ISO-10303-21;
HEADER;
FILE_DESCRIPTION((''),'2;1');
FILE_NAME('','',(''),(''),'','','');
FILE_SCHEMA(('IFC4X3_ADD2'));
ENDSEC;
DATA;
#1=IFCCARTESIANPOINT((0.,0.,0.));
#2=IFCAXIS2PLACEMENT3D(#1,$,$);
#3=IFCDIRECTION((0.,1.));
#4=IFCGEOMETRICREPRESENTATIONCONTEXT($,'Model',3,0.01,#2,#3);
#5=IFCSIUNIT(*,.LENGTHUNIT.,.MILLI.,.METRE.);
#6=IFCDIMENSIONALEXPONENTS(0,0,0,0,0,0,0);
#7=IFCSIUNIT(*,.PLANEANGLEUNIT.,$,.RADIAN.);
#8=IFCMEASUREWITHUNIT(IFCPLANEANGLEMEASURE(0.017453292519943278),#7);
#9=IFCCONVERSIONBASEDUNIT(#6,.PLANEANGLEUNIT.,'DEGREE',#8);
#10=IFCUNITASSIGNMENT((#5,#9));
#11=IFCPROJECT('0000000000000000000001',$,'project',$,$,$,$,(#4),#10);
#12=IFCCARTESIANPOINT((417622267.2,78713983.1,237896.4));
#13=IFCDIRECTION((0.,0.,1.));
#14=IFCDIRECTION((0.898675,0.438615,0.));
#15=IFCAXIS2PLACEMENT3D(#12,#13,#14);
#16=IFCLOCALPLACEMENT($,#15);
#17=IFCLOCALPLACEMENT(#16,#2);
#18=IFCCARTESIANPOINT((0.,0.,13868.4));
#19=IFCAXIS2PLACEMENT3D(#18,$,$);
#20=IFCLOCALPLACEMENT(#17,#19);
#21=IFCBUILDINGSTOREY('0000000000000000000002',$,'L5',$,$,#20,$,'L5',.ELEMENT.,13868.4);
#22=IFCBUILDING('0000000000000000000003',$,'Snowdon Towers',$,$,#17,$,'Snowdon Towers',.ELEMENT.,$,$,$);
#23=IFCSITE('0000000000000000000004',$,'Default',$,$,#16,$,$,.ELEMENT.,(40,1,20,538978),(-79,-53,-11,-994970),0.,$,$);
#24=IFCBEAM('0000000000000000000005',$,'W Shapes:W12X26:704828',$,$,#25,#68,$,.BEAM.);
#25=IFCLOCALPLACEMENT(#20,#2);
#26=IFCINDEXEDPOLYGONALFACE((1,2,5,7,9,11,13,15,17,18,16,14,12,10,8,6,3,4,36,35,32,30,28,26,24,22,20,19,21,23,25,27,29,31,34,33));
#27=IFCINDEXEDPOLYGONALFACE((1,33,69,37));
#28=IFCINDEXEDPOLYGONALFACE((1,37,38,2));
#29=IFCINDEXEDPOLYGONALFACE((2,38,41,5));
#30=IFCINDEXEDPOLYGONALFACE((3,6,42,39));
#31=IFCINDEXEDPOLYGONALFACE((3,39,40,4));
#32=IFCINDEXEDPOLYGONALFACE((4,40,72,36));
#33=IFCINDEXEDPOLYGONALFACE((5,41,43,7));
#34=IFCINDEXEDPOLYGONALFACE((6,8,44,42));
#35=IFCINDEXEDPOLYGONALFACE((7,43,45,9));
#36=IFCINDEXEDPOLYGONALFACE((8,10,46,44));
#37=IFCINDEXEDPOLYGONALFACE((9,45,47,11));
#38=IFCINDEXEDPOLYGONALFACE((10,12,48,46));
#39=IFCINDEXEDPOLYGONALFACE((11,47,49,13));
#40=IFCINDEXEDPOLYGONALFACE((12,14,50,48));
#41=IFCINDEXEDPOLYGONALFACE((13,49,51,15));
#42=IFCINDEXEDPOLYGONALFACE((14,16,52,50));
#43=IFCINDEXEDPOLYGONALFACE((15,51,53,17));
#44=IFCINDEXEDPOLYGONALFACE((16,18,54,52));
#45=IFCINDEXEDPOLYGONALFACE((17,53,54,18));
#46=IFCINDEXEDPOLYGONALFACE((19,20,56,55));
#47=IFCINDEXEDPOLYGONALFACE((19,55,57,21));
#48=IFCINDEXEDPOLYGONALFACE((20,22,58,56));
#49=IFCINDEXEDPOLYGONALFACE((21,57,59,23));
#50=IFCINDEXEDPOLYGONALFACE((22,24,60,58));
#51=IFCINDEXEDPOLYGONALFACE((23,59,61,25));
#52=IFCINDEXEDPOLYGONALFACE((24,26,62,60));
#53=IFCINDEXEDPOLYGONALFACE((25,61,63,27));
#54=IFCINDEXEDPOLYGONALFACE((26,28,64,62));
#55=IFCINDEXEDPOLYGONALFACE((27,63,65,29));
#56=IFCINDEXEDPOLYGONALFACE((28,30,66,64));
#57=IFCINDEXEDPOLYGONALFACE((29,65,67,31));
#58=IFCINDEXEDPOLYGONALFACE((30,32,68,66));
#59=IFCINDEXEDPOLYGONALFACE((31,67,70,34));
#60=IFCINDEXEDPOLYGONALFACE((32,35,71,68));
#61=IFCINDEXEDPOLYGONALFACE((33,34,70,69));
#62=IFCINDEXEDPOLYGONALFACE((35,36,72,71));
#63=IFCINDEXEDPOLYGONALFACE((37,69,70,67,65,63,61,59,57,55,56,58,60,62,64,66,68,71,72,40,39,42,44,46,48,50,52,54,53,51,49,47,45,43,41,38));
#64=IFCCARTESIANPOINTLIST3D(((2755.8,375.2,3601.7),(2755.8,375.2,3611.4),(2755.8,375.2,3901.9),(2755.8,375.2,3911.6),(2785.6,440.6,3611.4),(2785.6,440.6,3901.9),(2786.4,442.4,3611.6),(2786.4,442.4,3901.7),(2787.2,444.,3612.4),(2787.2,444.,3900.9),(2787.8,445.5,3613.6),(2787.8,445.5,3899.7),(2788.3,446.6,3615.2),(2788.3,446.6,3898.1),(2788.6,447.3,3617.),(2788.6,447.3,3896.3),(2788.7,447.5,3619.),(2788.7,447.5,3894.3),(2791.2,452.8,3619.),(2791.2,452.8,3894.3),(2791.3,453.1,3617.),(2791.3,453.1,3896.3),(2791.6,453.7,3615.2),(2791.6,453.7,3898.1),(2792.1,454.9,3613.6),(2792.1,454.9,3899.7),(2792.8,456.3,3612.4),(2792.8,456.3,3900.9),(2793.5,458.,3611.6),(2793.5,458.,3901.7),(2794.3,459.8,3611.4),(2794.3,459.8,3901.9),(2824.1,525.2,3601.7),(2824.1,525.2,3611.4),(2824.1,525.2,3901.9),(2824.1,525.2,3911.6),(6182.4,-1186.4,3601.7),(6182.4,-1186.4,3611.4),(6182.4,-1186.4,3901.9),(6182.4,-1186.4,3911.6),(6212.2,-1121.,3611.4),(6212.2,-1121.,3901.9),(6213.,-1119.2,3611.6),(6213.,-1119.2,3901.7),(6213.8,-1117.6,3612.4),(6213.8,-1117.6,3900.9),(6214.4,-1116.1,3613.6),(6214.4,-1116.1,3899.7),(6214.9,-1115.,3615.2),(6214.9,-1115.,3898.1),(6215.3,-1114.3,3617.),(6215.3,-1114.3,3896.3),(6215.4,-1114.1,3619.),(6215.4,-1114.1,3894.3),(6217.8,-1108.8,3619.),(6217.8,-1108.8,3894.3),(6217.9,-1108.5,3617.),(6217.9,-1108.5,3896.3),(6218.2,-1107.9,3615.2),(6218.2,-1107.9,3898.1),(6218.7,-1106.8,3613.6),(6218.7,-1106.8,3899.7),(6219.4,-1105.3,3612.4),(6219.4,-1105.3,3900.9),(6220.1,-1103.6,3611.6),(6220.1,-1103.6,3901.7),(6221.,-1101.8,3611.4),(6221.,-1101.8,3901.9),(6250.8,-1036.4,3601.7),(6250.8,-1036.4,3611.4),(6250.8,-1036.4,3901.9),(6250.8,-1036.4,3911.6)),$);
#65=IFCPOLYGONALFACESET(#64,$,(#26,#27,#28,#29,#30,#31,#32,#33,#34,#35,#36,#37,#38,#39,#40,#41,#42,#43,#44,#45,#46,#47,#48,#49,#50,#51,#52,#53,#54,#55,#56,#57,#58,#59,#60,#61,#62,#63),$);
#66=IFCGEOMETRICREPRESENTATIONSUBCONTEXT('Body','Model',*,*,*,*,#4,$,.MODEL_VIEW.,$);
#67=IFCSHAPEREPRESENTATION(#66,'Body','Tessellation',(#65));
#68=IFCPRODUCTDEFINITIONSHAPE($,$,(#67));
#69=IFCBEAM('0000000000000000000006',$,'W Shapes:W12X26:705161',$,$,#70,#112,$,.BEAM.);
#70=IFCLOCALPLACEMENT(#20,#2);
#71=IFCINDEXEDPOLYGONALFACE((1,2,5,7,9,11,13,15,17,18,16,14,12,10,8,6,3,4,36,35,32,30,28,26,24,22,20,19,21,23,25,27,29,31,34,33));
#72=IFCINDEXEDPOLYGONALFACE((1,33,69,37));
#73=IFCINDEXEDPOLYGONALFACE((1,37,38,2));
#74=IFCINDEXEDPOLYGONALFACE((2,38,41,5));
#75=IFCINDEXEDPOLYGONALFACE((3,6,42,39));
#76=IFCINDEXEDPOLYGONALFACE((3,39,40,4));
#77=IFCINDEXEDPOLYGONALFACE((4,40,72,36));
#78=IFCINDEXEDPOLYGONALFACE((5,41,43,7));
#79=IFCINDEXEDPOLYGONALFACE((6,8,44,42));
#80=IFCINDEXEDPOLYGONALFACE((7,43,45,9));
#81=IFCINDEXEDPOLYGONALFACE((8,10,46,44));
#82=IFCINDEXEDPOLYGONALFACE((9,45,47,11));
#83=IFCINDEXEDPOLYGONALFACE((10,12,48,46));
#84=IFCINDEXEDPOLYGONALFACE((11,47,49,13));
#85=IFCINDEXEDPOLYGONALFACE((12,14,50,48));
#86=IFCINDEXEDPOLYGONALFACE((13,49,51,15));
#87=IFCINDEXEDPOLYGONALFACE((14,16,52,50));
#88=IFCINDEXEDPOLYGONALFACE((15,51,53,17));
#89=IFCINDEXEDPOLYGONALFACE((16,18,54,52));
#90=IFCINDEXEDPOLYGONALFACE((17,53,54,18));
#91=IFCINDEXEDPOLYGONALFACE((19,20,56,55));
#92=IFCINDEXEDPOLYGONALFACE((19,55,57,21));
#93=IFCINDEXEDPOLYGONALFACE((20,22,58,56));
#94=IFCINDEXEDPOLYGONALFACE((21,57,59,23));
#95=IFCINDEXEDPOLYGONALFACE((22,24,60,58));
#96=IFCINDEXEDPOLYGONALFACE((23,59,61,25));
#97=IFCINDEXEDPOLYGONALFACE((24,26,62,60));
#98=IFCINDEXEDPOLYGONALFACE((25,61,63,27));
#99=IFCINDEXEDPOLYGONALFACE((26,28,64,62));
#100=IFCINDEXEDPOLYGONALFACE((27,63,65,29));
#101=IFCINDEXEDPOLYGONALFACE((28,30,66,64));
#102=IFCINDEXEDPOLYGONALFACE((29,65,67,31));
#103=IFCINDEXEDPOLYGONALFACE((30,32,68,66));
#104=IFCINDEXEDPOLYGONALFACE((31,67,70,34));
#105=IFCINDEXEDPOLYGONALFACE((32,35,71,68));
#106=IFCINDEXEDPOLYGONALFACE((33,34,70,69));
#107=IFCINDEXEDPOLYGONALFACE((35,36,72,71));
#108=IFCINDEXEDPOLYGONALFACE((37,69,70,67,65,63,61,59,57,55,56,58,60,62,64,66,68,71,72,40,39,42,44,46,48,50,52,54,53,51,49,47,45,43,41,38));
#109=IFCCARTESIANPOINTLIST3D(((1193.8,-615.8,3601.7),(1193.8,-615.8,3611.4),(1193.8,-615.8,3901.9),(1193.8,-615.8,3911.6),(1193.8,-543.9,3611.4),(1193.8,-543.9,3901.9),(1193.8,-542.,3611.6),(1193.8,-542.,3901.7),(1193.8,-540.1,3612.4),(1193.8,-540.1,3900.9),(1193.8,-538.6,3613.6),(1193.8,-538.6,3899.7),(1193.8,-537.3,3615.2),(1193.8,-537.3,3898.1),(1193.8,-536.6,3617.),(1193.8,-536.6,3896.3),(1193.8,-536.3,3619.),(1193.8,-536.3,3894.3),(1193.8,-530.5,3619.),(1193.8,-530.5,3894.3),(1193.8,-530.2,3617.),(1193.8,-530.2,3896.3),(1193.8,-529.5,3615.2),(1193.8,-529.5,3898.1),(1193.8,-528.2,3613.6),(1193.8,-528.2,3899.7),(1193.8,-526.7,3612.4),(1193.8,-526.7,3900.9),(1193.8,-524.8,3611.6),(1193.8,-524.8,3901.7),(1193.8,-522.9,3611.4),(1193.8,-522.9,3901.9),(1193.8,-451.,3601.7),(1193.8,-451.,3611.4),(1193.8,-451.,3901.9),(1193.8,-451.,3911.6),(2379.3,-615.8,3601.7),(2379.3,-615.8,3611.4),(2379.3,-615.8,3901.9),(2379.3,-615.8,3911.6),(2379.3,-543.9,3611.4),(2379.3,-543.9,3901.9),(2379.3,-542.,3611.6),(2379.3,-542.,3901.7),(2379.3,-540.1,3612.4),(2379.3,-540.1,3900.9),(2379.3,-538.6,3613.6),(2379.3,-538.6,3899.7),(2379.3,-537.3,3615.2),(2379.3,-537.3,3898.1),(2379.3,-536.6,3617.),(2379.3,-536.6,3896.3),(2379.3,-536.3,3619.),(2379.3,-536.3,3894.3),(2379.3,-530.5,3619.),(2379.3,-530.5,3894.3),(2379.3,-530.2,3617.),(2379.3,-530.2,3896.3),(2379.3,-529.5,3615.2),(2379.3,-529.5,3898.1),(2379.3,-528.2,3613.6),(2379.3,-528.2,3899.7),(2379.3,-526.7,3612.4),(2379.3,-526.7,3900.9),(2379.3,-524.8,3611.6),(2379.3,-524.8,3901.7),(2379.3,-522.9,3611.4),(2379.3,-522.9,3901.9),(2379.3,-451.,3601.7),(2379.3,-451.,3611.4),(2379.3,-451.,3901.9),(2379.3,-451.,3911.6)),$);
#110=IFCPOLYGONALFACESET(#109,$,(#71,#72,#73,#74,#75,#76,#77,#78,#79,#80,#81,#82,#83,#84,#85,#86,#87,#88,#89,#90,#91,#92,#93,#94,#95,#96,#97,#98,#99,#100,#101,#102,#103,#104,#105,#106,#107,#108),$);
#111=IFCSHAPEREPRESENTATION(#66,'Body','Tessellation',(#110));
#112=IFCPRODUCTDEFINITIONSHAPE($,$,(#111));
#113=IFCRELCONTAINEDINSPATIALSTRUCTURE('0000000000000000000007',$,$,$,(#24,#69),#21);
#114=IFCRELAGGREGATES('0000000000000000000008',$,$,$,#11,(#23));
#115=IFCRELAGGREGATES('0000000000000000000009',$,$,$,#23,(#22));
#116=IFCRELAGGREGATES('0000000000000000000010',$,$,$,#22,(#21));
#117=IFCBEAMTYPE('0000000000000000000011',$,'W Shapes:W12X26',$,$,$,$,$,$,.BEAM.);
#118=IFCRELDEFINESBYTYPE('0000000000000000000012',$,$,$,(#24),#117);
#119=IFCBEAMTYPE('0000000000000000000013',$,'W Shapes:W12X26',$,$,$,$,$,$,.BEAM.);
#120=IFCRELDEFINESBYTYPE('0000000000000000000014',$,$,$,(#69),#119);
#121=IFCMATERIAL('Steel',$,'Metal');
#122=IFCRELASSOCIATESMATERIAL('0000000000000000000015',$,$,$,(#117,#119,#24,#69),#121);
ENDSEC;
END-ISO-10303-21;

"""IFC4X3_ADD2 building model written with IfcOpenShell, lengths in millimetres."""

from ifc_helpers import new_model, entity, si_unit, converted_unit, direction, frame, frame_2d, origin, place, context, subcontext, project, spatial, polyline, circle_curve, parameter, trimmed, segment, composite_curve, i_section, outline, extrude, source, transform, mapped, material, material_profile, profile_set, profile_usage, type_object, type_shapes, element, save


model = new_model("IFC4X3_ADD2")

# Units and contexts
model_context = context("Model", 3, precision=0.01, world=origin(), true_north=direction((0.0, 1.0)))
body_context = subcontext(model_context, "Body", "Model", "MODEL_VIEW")
ifc_project = project(units=[si_unit("LENGTHUNIT", "METRE", prefix="MILLI"), converted_unit("PLANEANGLEUNIT", "DEGREE", entity("IfcPlaneAngleMeasure", 0.017453292519943278), si_unit("PLANEANGLEUNIT", "RADIAN"), dimensions=[0, 0, 0, 0, 0, 0, 0])], contexts=[model_context])

# Site, building, storey
site_placement = place(None, frame((417622267.2, 78713983.1, 237896.4), z_axis=(0.0, 0.0, 1.0), x_axis=(0.898675, 0.438615, 0.0)))
site = spatial("IfcSite", under=ifc_project, at=site_placement, Name="Default", CompositionType="ELEMENT", RefLatitude=(40, 1, 20, 538978), RefLongitude=(-79, -53, -11, -994970), RefElevation=0.0)
building_placement = place(site_placement, origin())
building = spatial("IfcBuilding", under=site, at=building_placement, Name="Snowdon Towers", LongName="Snowdon Towers", CompositionType="ELEMENT")
storey_placement = place(building_placement, frame((0.0, 0.0, 13868.4)))
storey = spatial("IfcBuildingStorey", under=building, at=storey_placement, Name="L5", LongName="L5", CompositionType="ELEMENT", Elevation=13868.4)

# Shared definitions
ifc_material_1 = material(Name="Steel", Category="Metal")

# Beams
ifc_material_profile_1 = material_profile(ifc_material_1, outline(composite_curve([segment(polyline([(-82.4, -145.3), (-82.4, -154.9)]), True, "CONTINUOUS"), segment(polyline([(-82.4, -154.9), (82.4, -154.9)]), True, "CONTINUOUS"), segment(polyline([(82.4, -154.9), (82.4, -145.3)]), True, "CONTINUOUS"), segment(polyline([(82.4, -145.3), (10.5, -145.3)]), True, "CONTINUOUS"), segment(trimmed(circle_curve(frame_2d((10.5, -137.7), x_axis=(1.0, 0.0)), 7.6), [parameter(180.0)], [parameter(270.0)], True, "PARAMETER"), False, "CONTINUOUS"), segment(polyline([(2.9, -137.7), (2.9, 137.7)]), True, "CONTINUOUS"), segment(trimmed(circle_curve(frame_2d((10.5, 137.7), x_axis=(1.0, 0.0)), 7.6), [parameter(90.0)], [parameter(180.0)], True, "PARAMETER"), False, "CONTINUOUS"), segment(polyline([(10.5, 145.3), (82.4, 145.3)]), True, "CONTINUOUS"), segment(polyline([(82.4, 145.3), (82.4, 154.9)]), True, "CONTINUOUS"), segment(polyline([(82.4, 154.9), (-82.4, 154.9)]), True, "CONTINUOUS"), segment(polyline([(-82.4, 154.9), (-82.4, 145.3)]), True, "CONTINUOUS"), segment(polyline([(-82.4, 145.3), (-10.5, 145.3)]), True, "CONTINUOUS"), segment(trimmed(circle_curve(frame_2d((-10.5, 137.7), x_axis=(1.0, 0.0)), 7.6), [parameter(360.0)], [parameter(90.0)], True, "PARAMETER"), False, "CONTINUOUS"), segment(polyline([(-2.9, 137.7), (-2.9, -137.7)]), True, "CONTINUOUS"), segment(trimmed(circle_curve(frame_2d((-10.5, -137.7), x_axis=(1.0, 0.0)), 7.6), [parameter(270.0)], [parameter(360.0)], True, "PARAMETER"), False, "CONTINUOUS"), segment(polyline([(-10.5, -145.3), (-82.4, -145.3)]), True, "CONTINUOUS")], self_intersect=False)), Name="W12X26")
ifc_profile_set_1 = profile_set([ifc_material_profile_1], Name="W12X26")
ifc_profile_usage_1 = profile_usage(ifc_profile_set_1, cardinal=8)
beam_type_1 = type_object("IfcBeamType", Name="W Shapes:W12X26", PredefinedType="BEAM", material=ifc_profile_set_1)
shared_shape_1 = source(origin(), body_context, "Body", "SweptSolid", [
    extrude(outline(composite_curve([segment(polyline([(-82.4, -145.3), (-82.4, -154.9)]), True, "CONTINUOUS"), segment(polyline([(-82.4, -154.9), (82.4, -154.9)]), True, "CONTINUOUS"), segment(polyline([(82.4, -154.9), (82.4, -145.3)]), True, "CONTINUOUS"), segment(polyline([(82.4, -145.3), (10.5, -145.3)]), True, "CONTINUOUS"), segment(trimmed(circle_curve(frame_2d((10.5, -137.7), x_axis=(1.0, 0.0)), 7.6), [parameter(180.0)], [parameter(270.0)], True, "PARAMETER"), False, "CONTINUOUS"), segment(polyline([(2.9, -137.7), (2.9, 137.7)]), True, "CONTINUOUS"), segment(trimmed(circle_curve(frame_2d((10.5, 137.7), x_axis=(1.0, 0.0)), 7.6), [parameter(90.0)], [parameter(180.0)], True, "PARAMETER"), False, "CONTINUOUS"), segment(polyline([(10.5, 145.3), (82.4, 145.3)]), True, "CONTINUOUS"), segment(polyline([(82.4, 145.3), (82.4, 154.9)]), True, "CONTINUOUS"), segment(polyline([(82.4, 154.9), (-82.4, 154.9)]), True, "CONTINUOUS"), segment(polyline([(-82.4, 154.9), (-82.4, 145.3)]), True, "CONTINUOUS"), segment(polyline([(-82.4, 145.3), (-10.5, 145.3)]), True, "CONTINUOUS"), segment(trimmed(circle_curve(frame_2d((-10.5, 137.7), x_axis=(1.0, 0.0)), 7.6), [parameter(360.0)], [parameter(90.0)], True, "PARAMETER"), False, "CONTINUOUS"), segment(polyline([(-2.9, 137.7), (-2.9, -137.7)]), True, "CONTINUOUS"), segment(trimmed(circle_curve(frame_2d((-10.5, -137.7), x_axis=(1.0, 0.0)), 7.6), [parameter(270.0)], [parameter(360.0)], True, "PARAMETER"), False, "CONTINUOUS"), segment(polyline([(-10.5, -145.3), (-82.4, -145.3)]), True, "CONTINUOUS")], self_intersect=False)), frame((-1898.8, 0.0, 0.0), z_axis=(-1.0, 0.0, 0.0), x_axis=(0.0, -1.0, 0.0)), (0.0, 0.0, -1.0), 3765.7),
])
type_shapes(beam_type_1, [shared_shape_1])
beam_1_placement = place(storey_placement, frame((4517.8, -337.2, 3756.7), z_axis=(0.0, 0.0, 1.0), x_axis=(0.909961, -0.414693, 0.0)))
element("IfcBeam", 1, at=beam_1_placement, inside=storey, type_object=beam_type_1, material=ifc_profile_usage_1, Name="W Shapes:W12X26:704828", PredefinedType="BEAM", context=body_context, shape_type="MappedRepresentation", body=[
    mapped(shared_shape_1, transform((0.0, 0.0, 0.0), scale=1.0)),
])
beam_type_2 = type_object("IfcBeamType", Name="W Shapes:W12X26", PredefinedType="BEAM", material=ifc_profile_set_1)
shared_shape_2 = source(origin(), body_context, "Body", "SweptSolid", [
    extrude(i_section(OverallWidth=164.8, OverallDepth=309.9, WebThickness=5.8, FlangeThickness=9.7, FilletRadius=7.6, at=frame_2d((0.0, 0.0), x_axis=(0.0, 1.0))), frame((1193.8, -533.4, 17625.1), z_axis=(1.0, 0.0, 0.0), x_axis=(0.0, 0.0, -1.0)), (0.0, 0.0, 1.0), 1185.5),
])
type_shapes(beam_type_2, [shared_shape_2])
beam_2_placement = place(storey_placement, frame((0.0, 0.0, -13868.4)))
element("IfcBeam", 2, at=beam_2_placement, inside=storey, type_object=beam_type_2, material=ifc_profile_usage_1, Name="W Shapes:W12X26:705161", PredefinedType="BEAM", context=body_context, shape_type="MappedRepresentation", body=[
    mapped(shared_shape_2, transform((0.0, 0.0, 0.0), scale=1.0)),
])

save(model, "model.ifc")
